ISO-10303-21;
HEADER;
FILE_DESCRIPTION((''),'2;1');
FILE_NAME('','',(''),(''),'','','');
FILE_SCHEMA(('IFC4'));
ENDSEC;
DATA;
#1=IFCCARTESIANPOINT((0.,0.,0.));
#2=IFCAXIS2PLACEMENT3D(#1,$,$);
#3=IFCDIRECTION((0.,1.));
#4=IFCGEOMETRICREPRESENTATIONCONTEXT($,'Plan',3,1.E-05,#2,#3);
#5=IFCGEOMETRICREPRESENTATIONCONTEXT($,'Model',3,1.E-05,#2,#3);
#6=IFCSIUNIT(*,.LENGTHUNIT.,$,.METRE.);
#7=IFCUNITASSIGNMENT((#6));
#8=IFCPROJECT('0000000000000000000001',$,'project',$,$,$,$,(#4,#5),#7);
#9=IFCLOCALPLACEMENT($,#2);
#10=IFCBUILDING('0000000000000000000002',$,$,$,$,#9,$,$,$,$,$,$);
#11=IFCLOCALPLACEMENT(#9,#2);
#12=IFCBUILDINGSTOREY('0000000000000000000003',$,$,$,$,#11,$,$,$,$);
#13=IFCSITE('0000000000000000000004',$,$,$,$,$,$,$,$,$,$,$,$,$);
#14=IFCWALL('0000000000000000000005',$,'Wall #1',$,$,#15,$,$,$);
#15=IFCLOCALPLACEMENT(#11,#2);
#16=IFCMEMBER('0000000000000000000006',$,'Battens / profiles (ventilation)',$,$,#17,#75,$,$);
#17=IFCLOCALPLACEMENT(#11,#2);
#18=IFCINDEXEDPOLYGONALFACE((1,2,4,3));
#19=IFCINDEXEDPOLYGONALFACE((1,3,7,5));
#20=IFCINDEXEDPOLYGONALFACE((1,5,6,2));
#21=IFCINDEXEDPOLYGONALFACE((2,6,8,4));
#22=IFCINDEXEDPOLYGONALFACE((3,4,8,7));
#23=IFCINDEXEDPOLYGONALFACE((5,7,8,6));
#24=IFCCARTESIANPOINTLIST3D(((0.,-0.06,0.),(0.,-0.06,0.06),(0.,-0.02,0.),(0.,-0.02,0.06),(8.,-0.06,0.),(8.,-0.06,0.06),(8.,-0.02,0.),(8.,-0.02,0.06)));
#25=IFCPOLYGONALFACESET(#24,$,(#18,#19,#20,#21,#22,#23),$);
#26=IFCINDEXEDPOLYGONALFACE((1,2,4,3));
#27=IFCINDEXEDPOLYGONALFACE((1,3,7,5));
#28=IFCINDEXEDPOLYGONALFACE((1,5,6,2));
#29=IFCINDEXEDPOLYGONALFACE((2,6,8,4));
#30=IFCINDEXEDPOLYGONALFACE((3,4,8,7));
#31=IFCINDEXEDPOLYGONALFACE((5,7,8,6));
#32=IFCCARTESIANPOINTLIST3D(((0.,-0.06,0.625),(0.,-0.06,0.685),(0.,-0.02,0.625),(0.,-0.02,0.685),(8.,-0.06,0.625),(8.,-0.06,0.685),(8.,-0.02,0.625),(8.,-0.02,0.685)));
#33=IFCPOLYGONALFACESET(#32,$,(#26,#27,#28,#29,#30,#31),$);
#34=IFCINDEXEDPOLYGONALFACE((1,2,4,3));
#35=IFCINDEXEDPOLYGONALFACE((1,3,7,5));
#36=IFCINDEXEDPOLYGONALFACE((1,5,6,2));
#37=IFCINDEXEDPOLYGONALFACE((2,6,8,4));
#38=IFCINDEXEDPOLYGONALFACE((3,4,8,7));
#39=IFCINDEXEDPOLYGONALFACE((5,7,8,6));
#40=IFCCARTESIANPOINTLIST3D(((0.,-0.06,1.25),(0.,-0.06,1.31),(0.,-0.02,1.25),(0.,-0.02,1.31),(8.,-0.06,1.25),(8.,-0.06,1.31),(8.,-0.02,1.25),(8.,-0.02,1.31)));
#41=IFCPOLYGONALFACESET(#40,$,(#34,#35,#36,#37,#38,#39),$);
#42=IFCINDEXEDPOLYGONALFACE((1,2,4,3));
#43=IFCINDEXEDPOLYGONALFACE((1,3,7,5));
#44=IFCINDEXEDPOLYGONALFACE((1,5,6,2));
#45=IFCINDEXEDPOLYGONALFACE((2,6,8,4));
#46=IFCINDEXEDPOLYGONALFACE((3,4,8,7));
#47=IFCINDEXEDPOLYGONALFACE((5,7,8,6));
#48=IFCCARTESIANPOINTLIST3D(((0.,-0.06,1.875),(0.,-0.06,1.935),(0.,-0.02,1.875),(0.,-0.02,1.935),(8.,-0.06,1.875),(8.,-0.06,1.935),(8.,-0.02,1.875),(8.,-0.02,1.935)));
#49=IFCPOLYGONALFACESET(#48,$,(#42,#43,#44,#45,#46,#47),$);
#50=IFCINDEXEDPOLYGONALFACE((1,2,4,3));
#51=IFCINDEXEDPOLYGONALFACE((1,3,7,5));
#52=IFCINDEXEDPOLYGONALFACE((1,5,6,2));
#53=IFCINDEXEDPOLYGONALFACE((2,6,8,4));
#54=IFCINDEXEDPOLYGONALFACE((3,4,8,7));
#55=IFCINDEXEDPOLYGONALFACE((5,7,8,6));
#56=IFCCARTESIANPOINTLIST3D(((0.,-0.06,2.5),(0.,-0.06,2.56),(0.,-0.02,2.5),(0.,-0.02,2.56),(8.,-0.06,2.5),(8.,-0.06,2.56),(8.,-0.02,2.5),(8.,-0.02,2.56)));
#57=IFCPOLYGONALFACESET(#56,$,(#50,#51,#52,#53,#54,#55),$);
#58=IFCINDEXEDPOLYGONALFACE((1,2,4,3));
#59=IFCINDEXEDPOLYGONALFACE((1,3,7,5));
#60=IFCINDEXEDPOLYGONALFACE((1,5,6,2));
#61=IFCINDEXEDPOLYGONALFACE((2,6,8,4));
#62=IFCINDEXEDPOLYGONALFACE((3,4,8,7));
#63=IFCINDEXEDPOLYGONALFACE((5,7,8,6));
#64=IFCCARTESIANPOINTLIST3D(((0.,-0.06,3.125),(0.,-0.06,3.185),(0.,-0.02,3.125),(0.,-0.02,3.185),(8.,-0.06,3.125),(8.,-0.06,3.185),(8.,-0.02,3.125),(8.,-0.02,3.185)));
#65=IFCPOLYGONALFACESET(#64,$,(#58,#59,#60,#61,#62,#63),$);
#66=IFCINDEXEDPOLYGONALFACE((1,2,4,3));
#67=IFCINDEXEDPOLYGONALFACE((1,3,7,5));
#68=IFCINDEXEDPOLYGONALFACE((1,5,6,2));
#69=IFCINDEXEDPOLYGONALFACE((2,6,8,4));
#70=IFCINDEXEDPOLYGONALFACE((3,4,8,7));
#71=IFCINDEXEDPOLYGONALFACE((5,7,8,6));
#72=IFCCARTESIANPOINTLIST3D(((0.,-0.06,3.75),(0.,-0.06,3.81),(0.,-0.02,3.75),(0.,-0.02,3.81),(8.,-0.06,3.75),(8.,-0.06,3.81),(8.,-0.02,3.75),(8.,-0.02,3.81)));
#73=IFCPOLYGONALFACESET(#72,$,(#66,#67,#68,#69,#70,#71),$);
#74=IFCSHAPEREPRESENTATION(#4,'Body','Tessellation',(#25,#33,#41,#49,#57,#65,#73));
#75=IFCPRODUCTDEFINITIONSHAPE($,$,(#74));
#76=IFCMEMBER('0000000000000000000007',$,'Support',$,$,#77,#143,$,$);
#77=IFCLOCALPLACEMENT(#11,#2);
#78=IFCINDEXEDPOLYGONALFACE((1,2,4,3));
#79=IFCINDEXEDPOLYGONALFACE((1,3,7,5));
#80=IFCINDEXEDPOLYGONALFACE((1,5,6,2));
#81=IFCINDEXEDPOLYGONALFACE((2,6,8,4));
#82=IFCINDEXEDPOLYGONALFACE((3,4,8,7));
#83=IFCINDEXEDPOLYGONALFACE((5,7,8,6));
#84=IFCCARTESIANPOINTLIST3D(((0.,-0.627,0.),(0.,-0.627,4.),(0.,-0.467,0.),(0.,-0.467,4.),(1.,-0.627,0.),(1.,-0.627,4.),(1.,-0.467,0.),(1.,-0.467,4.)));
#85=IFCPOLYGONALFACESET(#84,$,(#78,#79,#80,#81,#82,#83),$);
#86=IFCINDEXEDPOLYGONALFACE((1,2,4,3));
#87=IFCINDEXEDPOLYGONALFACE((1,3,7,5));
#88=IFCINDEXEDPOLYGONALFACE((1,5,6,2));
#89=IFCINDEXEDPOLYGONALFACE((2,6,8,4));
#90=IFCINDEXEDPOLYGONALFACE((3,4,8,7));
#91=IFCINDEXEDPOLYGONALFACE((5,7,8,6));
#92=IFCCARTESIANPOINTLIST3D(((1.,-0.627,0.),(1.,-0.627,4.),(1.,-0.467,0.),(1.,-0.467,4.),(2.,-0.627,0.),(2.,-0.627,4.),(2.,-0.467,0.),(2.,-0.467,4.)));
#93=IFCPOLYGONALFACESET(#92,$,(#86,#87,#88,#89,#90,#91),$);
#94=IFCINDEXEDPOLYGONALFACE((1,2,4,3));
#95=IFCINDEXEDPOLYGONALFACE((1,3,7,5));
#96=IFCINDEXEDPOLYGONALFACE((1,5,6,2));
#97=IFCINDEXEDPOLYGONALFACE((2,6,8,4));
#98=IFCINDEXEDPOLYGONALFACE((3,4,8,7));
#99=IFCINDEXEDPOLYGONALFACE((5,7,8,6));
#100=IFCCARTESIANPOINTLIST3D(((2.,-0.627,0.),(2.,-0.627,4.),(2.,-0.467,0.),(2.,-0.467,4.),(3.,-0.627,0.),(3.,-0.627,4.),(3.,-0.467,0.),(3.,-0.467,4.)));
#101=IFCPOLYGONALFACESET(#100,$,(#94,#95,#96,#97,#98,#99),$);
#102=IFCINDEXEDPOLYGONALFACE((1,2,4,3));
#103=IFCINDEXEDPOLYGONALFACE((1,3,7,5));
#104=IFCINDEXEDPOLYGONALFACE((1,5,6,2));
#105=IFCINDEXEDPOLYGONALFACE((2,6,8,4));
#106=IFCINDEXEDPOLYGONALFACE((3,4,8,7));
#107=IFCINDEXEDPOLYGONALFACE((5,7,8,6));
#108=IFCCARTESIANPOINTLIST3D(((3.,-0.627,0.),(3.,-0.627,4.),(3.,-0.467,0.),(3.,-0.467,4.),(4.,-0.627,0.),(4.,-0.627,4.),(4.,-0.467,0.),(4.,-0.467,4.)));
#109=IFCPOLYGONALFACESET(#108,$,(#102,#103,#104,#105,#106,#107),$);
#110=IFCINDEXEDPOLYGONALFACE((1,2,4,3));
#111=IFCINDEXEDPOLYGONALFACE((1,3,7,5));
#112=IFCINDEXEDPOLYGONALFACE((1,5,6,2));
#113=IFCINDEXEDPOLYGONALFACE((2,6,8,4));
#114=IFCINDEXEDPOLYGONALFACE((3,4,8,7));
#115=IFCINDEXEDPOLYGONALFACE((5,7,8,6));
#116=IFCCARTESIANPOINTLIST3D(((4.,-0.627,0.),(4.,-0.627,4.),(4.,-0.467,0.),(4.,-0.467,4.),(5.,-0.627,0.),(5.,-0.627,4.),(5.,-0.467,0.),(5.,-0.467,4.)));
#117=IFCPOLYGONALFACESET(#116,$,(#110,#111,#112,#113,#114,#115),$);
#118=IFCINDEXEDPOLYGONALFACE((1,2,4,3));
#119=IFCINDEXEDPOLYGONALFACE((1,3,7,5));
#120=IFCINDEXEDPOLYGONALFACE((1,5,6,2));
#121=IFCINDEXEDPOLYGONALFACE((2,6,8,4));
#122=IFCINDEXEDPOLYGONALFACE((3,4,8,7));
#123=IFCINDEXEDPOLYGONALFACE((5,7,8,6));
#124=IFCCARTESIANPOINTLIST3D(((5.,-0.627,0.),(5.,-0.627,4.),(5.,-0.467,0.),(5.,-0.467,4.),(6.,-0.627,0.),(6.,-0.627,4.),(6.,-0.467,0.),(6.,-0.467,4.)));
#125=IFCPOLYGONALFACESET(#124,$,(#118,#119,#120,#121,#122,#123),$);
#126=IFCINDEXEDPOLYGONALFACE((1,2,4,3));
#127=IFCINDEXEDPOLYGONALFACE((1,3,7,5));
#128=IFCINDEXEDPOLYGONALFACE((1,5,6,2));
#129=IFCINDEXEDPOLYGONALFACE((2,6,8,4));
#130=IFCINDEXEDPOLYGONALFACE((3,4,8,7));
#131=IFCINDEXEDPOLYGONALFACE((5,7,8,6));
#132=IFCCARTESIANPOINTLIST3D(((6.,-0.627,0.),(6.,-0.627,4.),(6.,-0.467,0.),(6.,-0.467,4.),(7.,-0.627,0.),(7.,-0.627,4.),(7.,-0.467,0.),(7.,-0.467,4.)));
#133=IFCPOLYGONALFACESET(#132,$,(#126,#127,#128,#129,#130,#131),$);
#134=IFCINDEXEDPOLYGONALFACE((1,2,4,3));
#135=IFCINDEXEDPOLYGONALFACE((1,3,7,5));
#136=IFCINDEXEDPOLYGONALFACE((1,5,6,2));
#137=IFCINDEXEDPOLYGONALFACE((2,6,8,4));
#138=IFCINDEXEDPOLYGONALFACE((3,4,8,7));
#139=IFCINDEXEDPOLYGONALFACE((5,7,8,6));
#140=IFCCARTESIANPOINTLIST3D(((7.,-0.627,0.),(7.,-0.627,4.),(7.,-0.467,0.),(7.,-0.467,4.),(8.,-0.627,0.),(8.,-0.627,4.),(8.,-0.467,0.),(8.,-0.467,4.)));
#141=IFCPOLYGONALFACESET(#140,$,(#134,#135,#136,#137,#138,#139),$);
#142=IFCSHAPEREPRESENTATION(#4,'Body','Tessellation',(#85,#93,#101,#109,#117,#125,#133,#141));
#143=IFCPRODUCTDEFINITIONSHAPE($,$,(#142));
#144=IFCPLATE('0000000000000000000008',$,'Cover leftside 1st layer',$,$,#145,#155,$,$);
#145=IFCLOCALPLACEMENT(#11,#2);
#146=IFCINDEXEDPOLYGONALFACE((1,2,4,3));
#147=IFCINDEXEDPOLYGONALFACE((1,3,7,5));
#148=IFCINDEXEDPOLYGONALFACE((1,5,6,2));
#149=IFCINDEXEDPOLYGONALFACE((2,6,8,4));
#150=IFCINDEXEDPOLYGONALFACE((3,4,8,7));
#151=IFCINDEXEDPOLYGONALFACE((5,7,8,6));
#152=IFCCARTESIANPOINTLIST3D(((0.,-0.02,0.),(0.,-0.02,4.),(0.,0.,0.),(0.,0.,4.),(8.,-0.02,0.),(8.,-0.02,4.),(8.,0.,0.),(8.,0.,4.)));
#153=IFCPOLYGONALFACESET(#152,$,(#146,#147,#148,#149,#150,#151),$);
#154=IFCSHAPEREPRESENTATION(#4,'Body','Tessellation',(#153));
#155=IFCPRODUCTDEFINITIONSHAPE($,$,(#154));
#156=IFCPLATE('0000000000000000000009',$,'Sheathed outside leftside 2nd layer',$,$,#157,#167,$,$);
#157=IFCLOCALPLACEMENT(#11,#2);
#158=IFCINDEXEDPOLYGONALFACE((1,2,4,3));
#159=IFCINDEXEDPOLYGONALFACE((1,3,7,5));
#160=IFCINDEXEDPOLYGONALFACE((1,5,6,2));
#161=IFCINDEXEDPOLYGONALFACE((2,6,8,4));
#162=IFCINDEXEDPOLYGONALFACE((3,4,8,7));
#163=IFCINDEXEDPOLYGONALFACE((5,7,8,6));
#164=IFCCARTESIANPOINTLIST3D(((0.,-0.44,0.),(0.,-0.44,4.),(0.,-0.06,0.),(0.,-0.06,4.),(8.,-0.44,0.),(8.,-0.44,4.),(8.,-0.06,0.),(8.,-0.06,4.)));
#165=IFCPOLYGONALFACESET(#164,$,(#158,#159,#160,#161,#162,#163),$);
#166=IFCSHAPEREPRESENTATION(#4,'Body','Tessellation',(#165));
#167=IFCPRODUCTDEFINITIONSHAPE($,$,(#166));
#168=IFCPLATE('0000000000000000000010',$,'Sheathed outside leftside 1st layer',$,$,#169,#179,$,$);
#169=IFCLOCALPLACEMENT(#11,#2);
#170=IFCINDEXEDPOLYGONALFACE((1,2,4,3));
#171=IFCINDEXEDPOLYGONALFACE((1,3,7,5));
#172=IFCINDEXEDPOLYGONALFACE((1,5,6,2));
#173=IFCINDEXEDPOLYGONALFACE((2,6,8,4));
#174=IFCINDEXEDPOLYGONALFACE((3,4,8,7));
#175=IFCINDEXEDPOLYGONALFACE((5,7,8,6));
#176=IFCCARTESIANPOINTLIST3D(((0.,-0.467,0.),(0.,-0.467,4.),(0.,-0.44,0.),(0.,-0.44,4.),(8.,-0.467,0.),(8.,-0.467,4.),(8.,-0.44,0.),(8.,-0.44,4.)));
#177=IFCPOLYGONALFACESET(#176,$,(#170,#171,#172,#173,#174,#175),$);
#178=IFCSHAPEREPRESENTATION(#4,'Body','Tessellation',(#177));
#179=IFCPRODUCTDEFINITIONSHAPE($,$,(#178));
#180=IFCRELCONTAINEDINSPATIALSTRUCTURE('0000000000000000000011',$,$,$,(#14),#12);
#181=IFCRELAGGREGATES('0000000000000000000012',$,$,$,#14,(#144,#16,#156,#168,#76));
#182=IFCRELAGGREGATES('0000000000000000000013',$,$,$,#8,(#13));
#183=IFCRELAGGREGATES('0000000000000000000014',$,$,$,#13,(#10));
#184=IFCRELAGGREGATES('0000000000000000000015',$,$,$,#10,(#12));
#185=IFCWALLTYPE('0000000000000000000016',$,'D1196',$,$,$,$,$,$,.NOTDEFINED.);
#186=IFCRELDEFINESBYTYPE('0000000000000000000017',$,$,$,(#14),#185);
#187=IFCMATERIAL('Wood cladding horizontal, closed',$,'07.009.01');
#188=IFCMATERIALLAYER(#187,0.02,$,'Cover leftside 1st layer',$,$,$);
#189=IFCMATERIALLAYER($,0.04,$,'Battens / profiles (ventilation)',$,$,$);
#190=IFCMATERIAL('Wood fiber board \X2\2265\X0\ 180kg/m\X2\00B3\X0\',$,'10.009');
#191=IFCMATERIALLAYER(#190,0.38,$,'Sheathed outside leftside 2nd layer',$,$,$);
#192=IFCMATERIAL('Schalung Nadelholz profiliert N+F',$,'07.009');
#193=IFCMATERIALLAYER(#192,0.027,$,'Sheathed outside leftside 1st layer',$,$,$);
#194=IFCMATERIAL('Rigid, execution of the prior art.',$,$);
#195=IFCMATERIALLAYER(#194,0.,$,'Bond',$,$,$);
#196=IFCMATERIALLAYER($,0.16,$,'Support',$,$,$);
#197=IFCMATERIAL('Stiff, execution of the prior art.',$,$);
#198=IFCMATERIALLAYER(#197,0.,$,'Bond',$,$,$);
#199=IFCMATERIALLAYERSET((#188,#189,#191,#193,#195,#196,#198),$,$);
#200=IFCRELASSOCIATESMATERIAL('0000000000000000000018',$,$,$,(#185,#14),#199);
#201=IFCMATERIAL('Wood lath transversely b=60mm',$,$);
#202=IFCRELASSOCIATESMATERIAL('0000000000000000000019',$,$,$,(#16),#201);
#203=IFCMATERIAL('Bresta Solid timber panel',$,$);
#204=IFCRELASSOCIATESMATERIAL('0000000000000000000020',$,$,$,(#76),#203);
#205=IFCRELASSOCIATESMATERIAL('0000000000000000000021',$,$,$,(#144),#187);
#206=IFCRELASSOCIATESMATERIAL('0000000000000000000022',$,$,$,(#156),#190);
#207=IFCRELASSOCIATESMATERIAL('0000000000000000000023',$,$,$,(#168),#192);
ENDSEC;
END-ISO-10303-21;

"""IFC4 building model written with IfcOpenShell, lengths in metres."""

from ifc_helpers import new_model, si_unit, direction, frame, frame_2d, origin, origin_with_axes, place, context, project, spatial, rectangle, extrude, material, layer, layer_set, type_object, element, aggregate, save


model = new_model("IFC4")

# Units and contexts
plan_context = context("Plan", 3, precision=1e-05, world=origin(), true_north=direction((0.0, 1.0)))
model_context = context("Model", 3, precision=1e-05, world=origin(), true_north=direction((0.0, 1.0)))
ifc_project = project(units=[si_unit("LENGTHUNIT", "METRE")], contexts=[plan_context, model_context])

# Site, building, storey
site = spatial("IfcSite", under=ifc_project)
building_placement = place(None, origin())
building = spatial("IfcBuilding", under=site, at=building_placement)
storey_placement = place(building_placement, origin())
storey = spatial("IfcBuildingStorey", under=building, at=storey_placement)

# Wall, members, plates
ifc_material_1 = material(Name="Wood cladding horizontal, closed", Category="07.009.01")
ifc_layer_1 = layer(ifc_material_1, 0.02, Name="Cover leftside 1st layer")
ifc_layer_2 = layer(None, 0.04, Name="Battens / profiles (ventilation)")
ifc_material_2 = material(Name="Wood fiber board ≥ 180kg/m³", Category="10.009")
ifc_layer_3 = layer(ifc_material_2, 0.38, Name="Sheathed outside leftside 2nd layer")
ifc_material_3 = material(Name="Schalung Nadelholz profiliert N+F", Category="07.009")
ifc_layer_4 = layer(ifc_material_3, 0.027, Name="Sheathed outside leftside 1st layer")
ifc_material_4 = material(Name="Rigid, execution of the prior art.")
ifc_layer_5 = layer(ifc_material_4, 0.0, Name="Bond")
ifc_layer_6 = layer(None, 0.16, Name="Support")
ifc_material_5 = material(Name="Stiff, execution of the prior art.")
ifc_layer_7 = layer(ifc_material_5, 0.0, Name="Bond")
ifc_layer_set = layer_set([ifc_layer_1, ifc_layer_2, ifc_layer_3, ifc_layer_4, ifc_layer_5, ifc_layer_6, ifc_layer_7])
wall_type = type_object("IfcWallType", Name="D1196", PredefinedType="NOTDEFINED", material=ifc_layer_set)
wall_placement = place(None, frame((0.0, 0.0, 0.0), z_axis=(0.0, -1.0, 0.0), x_axis=(1.0, 0.0, 0.0)))
wall = element("IfcWall", 1, at=wall_placement, inside=storey, type_object=wall_type, material=ifc_layer_set, Name="Wall #1")
ifc_material_6 = material(Name="Wood lath transversely b=60mm")
member_1_placement = place(wall_placement, origin())
member_1 = element("IfcMember", 2, at=member_1_placement, material=ifc_material_6, Name="Battens / profiles (ventilation)", context=plan_context, shape_type="SweptSolid", body=[
    extrude(rectangle(XDim=0.06, YDim=0.04, at=frame_2d((0.03, 0.02), x_axis=(1.0, 0.0))), frame((0.0, 0.0, 0.02), z_axis=(1.0, 0.0, 0.0), x_axis=(0.0, 1.0, 0.0)), (0.0, 0.0, 1.0), 8.0),
    extrude(rectangle(XDim=0.06, YDim=0.04, at=frame_2d((0.03, 0.02), x_axis=(1.0, 0.0))), frame((0.0, 0.625, 0.02), z_axis=(1.0, 0.0, 0.0), x_axis=(0.0, 1.0, 0.0)), (0.0, 0.0, 1.0), 8.0),
    extrude(rectangle(XDim=0.06, YDim=0.04, at=frame_2d((0.03, 0.02), x_axis=(1.0, 0.0))), frame((0.0, 1.25, 0.02), z_axis=(1.0, 0.0, 0.0), x_axis=(0.0, 1.0, 0.0)), (0.0, 0.0, 1.0), 8.0),
    extrude(rectangle(XDim=0.06, YDim=0.04, at=frame_2d((0.03, 0.02), x_axis=(1.0, 0.0))), frame((0.0, 1.875, 0.02), z_axis=(1.0, 0.0, 0.0), x_axis=(0.0, 1.0, 0.0)), (0.0, 0.0, 1.0), 8.0),
    extrude(rectangle(XDim=0.06, YDim=0.04, at=frame_2d((0.03, 0.02), x_axis=(1.0, 0.0))), frame((0.0, 2.5, 0.02), z_axis=(1.0, 0.0, 0.0), x_axis=(0.0, 1.0, 0.0)), (0.0, 0.0, 1.0), 8.0),
    extrude(rectangle(XDim=0.06, YDim=0.04, at=frame_2d((0.03, 0.02), x_axis=(1.0, 0.0))), frame((0.0, 3.125, 0.02), z_axis=(1.0, 0.0, 0.0), x_axis=(0.0, 1.0, 0.0)), (0.0, 0.0, 1.0), 8.0),
    extrude(rectangle(XDim=0.06, YDim=0.04, at=frame_2d((0.03, 0.02), x_axis=(1.0, 0.0))), frame((0.0, 3.75, 0.02), z_axis=(1.0, 0.0, 0.0), x_axis=(0.0, 1.0, 0.0)), (0.0, 0.0, 1.0), 8.0),
])
ifc_material_7 = material(Name="Bresta Solid timber panel")
member_2_placement = place(wall_placement, origin())
member_2 = element("IfcMember", 3, at=member_2_placement, material=ifc_material_7, Name="Support", context=plan_context, shape_type="SweptSolid", body=[
    extrude(rectangle(XDim=1.0, YDim=0.16, at=frame_2d((0.5, 0.08), x_axis=(1.0, 0.0))), frame((0.0, 4.0, 0.467), z_axis=(0.0, -1.0, 0.0), x_axis=(1.0, 0.0, 0.0)), (0.0, 0.0, 1.0), 4.0),
    extrude(rectangle(XDim=1.0, YDim=0.16, at=frame_2d((0.5, 0.08), x_axis=(1.0, 0.0))), frame((1.0, 4.0, 0.467), z_axis=(0.0, -1.0, 0.0), x_axis=(1.0, 0.0, 0.0)), (0.0, 0.0, 1.0), 4.0),
    extrude(rectangle(XDim=1.0, YDim=0.16, at=frame_2d((0.5, 0.08), x_axis=(1.0, 0.0))), frame((2.0, 4.0, 0.467), z_axis=(0.0, -1.0, 0.0), x_axis=(1.0, 0.0, 0.0)), (0.0, 0.0, 1.0), 4.0),
    extrude(rectangle(XDim=1.0, YDim=0.16, at=frame_2d((0.5, 0.08), x_axis=(1.0, 0.0))), frame((3.0, 4.0, 0.467), z_axis=(0.0, -1.0, 0.0), x_axis=(1.0, 0.0, 0.0)), (0.0, 0.0, 1.0), 4.0),
    extrude(rectangle(XDim=1.0, YDim=0.16, at=frame_2d((0.5, 0.08), x_axis=(1.0, 0.0))), frame((4.0, 4.0, 0.467), z_axis=(0.0, -1.0, 0.0), x_axis=(1.0, 0.0, 0.0)), (0.0, 0.0, 1.0), 4.0),
    extrude(rectangle(XDim=1.0, YDim=0.16, at=frame_2d((0.5, 0.08), x_axis=(1.0, 0.0))), frame((5.0, 4.0, 0.467), z_axis=(0.0, -1.0, 0.0), x_axis=(1.0, 0.0, 0.0)), (0.0, 0.0, 1.0), 4.0),
    extrude(rectangle(XDim=1.0, YDim=0.16, at=frame_2d((0.5, 0.08), x_axis=(1.0, 0.0))), frame((6.0, 4.0, 0.467), z_axis=(0.0, -1.0, 0.0), x_axis=(1.0, 0.0, 0.0)), (0.0, 0.0, 1.0), 4.0),
    extrude(rectangle(XDim=1.0, YDim=0.16, at=frame_2d((0.5, 0.08), x_axis=(1.0, 0.0))), frame((7.0, 4.0, 0.467), z_axis=(0.0, -1.0, 0.0), x_axis=(1.0, 0.0, 0.0)), (0.0, 0.0, 1.0), 4.0),
])
plate_1_placement = place(wall_placement, origin())
plate_1 = element("IfcPlate", 4, at=plate_1_placement, material=ifc_material_1, Name="Cover leftside 1st layer", context=plan_context, shape_type="SweptSolid", body=[
    extrude(rectangle(XDim=8.0, YDim=4.0, at=frame_2d((4.0, 2.0), x_axis=(1.0, 0.0))), origin_with_axes(), (0.0, 0.0, 1.0), 0.02),
])
plate_2_placement = place(wall_placement, origin())
plate_2 = element("IfcPlate", 5, at=plate_2_placement, material=ifc_material_2, Name="Sheathed outside leftside 2nd layer", context=plan_context, shape_type="SweptSolid", body=[
    extrude(rectangle(XDim=8.0, YDim=4.0, at=frame_2d((4.0, 2.0), x_axis=(1.0, 0.0))), frame((0.0, 0.0, 0.06), z_axis=(0.0, 0.0, 1.0), x_axis=(1.0, 0.0, 0.0)), (0.0, 0.0, 1.0), 0.38),
])
plate_3_placement = place(wall_placement, origin())
plate_3 = element("IfcPlate", 6, at=plate_3_placement, material=ifc_material_3, Name="Sheathed outside leftside 1st layer", context=plan_context, shape_type="SweptSolid", body=[
    extrude(rectangle(XDim=8.0, YDim=4.0, at=frame_2d((4.0, 2.0), x_axis=(1.0, 0.0))), frame((0.0, 0.0, 0.44), z_axis=(0.0, 0.0, 1.0), x_axis=(1.0, 0.0, 0.0)), (0.0, 0.0, 1.0), 0.027),
])
aggregate(wall, [plate_1, member_1, plate_2, plate_3, member_2])

save(model, "model.ifc")
